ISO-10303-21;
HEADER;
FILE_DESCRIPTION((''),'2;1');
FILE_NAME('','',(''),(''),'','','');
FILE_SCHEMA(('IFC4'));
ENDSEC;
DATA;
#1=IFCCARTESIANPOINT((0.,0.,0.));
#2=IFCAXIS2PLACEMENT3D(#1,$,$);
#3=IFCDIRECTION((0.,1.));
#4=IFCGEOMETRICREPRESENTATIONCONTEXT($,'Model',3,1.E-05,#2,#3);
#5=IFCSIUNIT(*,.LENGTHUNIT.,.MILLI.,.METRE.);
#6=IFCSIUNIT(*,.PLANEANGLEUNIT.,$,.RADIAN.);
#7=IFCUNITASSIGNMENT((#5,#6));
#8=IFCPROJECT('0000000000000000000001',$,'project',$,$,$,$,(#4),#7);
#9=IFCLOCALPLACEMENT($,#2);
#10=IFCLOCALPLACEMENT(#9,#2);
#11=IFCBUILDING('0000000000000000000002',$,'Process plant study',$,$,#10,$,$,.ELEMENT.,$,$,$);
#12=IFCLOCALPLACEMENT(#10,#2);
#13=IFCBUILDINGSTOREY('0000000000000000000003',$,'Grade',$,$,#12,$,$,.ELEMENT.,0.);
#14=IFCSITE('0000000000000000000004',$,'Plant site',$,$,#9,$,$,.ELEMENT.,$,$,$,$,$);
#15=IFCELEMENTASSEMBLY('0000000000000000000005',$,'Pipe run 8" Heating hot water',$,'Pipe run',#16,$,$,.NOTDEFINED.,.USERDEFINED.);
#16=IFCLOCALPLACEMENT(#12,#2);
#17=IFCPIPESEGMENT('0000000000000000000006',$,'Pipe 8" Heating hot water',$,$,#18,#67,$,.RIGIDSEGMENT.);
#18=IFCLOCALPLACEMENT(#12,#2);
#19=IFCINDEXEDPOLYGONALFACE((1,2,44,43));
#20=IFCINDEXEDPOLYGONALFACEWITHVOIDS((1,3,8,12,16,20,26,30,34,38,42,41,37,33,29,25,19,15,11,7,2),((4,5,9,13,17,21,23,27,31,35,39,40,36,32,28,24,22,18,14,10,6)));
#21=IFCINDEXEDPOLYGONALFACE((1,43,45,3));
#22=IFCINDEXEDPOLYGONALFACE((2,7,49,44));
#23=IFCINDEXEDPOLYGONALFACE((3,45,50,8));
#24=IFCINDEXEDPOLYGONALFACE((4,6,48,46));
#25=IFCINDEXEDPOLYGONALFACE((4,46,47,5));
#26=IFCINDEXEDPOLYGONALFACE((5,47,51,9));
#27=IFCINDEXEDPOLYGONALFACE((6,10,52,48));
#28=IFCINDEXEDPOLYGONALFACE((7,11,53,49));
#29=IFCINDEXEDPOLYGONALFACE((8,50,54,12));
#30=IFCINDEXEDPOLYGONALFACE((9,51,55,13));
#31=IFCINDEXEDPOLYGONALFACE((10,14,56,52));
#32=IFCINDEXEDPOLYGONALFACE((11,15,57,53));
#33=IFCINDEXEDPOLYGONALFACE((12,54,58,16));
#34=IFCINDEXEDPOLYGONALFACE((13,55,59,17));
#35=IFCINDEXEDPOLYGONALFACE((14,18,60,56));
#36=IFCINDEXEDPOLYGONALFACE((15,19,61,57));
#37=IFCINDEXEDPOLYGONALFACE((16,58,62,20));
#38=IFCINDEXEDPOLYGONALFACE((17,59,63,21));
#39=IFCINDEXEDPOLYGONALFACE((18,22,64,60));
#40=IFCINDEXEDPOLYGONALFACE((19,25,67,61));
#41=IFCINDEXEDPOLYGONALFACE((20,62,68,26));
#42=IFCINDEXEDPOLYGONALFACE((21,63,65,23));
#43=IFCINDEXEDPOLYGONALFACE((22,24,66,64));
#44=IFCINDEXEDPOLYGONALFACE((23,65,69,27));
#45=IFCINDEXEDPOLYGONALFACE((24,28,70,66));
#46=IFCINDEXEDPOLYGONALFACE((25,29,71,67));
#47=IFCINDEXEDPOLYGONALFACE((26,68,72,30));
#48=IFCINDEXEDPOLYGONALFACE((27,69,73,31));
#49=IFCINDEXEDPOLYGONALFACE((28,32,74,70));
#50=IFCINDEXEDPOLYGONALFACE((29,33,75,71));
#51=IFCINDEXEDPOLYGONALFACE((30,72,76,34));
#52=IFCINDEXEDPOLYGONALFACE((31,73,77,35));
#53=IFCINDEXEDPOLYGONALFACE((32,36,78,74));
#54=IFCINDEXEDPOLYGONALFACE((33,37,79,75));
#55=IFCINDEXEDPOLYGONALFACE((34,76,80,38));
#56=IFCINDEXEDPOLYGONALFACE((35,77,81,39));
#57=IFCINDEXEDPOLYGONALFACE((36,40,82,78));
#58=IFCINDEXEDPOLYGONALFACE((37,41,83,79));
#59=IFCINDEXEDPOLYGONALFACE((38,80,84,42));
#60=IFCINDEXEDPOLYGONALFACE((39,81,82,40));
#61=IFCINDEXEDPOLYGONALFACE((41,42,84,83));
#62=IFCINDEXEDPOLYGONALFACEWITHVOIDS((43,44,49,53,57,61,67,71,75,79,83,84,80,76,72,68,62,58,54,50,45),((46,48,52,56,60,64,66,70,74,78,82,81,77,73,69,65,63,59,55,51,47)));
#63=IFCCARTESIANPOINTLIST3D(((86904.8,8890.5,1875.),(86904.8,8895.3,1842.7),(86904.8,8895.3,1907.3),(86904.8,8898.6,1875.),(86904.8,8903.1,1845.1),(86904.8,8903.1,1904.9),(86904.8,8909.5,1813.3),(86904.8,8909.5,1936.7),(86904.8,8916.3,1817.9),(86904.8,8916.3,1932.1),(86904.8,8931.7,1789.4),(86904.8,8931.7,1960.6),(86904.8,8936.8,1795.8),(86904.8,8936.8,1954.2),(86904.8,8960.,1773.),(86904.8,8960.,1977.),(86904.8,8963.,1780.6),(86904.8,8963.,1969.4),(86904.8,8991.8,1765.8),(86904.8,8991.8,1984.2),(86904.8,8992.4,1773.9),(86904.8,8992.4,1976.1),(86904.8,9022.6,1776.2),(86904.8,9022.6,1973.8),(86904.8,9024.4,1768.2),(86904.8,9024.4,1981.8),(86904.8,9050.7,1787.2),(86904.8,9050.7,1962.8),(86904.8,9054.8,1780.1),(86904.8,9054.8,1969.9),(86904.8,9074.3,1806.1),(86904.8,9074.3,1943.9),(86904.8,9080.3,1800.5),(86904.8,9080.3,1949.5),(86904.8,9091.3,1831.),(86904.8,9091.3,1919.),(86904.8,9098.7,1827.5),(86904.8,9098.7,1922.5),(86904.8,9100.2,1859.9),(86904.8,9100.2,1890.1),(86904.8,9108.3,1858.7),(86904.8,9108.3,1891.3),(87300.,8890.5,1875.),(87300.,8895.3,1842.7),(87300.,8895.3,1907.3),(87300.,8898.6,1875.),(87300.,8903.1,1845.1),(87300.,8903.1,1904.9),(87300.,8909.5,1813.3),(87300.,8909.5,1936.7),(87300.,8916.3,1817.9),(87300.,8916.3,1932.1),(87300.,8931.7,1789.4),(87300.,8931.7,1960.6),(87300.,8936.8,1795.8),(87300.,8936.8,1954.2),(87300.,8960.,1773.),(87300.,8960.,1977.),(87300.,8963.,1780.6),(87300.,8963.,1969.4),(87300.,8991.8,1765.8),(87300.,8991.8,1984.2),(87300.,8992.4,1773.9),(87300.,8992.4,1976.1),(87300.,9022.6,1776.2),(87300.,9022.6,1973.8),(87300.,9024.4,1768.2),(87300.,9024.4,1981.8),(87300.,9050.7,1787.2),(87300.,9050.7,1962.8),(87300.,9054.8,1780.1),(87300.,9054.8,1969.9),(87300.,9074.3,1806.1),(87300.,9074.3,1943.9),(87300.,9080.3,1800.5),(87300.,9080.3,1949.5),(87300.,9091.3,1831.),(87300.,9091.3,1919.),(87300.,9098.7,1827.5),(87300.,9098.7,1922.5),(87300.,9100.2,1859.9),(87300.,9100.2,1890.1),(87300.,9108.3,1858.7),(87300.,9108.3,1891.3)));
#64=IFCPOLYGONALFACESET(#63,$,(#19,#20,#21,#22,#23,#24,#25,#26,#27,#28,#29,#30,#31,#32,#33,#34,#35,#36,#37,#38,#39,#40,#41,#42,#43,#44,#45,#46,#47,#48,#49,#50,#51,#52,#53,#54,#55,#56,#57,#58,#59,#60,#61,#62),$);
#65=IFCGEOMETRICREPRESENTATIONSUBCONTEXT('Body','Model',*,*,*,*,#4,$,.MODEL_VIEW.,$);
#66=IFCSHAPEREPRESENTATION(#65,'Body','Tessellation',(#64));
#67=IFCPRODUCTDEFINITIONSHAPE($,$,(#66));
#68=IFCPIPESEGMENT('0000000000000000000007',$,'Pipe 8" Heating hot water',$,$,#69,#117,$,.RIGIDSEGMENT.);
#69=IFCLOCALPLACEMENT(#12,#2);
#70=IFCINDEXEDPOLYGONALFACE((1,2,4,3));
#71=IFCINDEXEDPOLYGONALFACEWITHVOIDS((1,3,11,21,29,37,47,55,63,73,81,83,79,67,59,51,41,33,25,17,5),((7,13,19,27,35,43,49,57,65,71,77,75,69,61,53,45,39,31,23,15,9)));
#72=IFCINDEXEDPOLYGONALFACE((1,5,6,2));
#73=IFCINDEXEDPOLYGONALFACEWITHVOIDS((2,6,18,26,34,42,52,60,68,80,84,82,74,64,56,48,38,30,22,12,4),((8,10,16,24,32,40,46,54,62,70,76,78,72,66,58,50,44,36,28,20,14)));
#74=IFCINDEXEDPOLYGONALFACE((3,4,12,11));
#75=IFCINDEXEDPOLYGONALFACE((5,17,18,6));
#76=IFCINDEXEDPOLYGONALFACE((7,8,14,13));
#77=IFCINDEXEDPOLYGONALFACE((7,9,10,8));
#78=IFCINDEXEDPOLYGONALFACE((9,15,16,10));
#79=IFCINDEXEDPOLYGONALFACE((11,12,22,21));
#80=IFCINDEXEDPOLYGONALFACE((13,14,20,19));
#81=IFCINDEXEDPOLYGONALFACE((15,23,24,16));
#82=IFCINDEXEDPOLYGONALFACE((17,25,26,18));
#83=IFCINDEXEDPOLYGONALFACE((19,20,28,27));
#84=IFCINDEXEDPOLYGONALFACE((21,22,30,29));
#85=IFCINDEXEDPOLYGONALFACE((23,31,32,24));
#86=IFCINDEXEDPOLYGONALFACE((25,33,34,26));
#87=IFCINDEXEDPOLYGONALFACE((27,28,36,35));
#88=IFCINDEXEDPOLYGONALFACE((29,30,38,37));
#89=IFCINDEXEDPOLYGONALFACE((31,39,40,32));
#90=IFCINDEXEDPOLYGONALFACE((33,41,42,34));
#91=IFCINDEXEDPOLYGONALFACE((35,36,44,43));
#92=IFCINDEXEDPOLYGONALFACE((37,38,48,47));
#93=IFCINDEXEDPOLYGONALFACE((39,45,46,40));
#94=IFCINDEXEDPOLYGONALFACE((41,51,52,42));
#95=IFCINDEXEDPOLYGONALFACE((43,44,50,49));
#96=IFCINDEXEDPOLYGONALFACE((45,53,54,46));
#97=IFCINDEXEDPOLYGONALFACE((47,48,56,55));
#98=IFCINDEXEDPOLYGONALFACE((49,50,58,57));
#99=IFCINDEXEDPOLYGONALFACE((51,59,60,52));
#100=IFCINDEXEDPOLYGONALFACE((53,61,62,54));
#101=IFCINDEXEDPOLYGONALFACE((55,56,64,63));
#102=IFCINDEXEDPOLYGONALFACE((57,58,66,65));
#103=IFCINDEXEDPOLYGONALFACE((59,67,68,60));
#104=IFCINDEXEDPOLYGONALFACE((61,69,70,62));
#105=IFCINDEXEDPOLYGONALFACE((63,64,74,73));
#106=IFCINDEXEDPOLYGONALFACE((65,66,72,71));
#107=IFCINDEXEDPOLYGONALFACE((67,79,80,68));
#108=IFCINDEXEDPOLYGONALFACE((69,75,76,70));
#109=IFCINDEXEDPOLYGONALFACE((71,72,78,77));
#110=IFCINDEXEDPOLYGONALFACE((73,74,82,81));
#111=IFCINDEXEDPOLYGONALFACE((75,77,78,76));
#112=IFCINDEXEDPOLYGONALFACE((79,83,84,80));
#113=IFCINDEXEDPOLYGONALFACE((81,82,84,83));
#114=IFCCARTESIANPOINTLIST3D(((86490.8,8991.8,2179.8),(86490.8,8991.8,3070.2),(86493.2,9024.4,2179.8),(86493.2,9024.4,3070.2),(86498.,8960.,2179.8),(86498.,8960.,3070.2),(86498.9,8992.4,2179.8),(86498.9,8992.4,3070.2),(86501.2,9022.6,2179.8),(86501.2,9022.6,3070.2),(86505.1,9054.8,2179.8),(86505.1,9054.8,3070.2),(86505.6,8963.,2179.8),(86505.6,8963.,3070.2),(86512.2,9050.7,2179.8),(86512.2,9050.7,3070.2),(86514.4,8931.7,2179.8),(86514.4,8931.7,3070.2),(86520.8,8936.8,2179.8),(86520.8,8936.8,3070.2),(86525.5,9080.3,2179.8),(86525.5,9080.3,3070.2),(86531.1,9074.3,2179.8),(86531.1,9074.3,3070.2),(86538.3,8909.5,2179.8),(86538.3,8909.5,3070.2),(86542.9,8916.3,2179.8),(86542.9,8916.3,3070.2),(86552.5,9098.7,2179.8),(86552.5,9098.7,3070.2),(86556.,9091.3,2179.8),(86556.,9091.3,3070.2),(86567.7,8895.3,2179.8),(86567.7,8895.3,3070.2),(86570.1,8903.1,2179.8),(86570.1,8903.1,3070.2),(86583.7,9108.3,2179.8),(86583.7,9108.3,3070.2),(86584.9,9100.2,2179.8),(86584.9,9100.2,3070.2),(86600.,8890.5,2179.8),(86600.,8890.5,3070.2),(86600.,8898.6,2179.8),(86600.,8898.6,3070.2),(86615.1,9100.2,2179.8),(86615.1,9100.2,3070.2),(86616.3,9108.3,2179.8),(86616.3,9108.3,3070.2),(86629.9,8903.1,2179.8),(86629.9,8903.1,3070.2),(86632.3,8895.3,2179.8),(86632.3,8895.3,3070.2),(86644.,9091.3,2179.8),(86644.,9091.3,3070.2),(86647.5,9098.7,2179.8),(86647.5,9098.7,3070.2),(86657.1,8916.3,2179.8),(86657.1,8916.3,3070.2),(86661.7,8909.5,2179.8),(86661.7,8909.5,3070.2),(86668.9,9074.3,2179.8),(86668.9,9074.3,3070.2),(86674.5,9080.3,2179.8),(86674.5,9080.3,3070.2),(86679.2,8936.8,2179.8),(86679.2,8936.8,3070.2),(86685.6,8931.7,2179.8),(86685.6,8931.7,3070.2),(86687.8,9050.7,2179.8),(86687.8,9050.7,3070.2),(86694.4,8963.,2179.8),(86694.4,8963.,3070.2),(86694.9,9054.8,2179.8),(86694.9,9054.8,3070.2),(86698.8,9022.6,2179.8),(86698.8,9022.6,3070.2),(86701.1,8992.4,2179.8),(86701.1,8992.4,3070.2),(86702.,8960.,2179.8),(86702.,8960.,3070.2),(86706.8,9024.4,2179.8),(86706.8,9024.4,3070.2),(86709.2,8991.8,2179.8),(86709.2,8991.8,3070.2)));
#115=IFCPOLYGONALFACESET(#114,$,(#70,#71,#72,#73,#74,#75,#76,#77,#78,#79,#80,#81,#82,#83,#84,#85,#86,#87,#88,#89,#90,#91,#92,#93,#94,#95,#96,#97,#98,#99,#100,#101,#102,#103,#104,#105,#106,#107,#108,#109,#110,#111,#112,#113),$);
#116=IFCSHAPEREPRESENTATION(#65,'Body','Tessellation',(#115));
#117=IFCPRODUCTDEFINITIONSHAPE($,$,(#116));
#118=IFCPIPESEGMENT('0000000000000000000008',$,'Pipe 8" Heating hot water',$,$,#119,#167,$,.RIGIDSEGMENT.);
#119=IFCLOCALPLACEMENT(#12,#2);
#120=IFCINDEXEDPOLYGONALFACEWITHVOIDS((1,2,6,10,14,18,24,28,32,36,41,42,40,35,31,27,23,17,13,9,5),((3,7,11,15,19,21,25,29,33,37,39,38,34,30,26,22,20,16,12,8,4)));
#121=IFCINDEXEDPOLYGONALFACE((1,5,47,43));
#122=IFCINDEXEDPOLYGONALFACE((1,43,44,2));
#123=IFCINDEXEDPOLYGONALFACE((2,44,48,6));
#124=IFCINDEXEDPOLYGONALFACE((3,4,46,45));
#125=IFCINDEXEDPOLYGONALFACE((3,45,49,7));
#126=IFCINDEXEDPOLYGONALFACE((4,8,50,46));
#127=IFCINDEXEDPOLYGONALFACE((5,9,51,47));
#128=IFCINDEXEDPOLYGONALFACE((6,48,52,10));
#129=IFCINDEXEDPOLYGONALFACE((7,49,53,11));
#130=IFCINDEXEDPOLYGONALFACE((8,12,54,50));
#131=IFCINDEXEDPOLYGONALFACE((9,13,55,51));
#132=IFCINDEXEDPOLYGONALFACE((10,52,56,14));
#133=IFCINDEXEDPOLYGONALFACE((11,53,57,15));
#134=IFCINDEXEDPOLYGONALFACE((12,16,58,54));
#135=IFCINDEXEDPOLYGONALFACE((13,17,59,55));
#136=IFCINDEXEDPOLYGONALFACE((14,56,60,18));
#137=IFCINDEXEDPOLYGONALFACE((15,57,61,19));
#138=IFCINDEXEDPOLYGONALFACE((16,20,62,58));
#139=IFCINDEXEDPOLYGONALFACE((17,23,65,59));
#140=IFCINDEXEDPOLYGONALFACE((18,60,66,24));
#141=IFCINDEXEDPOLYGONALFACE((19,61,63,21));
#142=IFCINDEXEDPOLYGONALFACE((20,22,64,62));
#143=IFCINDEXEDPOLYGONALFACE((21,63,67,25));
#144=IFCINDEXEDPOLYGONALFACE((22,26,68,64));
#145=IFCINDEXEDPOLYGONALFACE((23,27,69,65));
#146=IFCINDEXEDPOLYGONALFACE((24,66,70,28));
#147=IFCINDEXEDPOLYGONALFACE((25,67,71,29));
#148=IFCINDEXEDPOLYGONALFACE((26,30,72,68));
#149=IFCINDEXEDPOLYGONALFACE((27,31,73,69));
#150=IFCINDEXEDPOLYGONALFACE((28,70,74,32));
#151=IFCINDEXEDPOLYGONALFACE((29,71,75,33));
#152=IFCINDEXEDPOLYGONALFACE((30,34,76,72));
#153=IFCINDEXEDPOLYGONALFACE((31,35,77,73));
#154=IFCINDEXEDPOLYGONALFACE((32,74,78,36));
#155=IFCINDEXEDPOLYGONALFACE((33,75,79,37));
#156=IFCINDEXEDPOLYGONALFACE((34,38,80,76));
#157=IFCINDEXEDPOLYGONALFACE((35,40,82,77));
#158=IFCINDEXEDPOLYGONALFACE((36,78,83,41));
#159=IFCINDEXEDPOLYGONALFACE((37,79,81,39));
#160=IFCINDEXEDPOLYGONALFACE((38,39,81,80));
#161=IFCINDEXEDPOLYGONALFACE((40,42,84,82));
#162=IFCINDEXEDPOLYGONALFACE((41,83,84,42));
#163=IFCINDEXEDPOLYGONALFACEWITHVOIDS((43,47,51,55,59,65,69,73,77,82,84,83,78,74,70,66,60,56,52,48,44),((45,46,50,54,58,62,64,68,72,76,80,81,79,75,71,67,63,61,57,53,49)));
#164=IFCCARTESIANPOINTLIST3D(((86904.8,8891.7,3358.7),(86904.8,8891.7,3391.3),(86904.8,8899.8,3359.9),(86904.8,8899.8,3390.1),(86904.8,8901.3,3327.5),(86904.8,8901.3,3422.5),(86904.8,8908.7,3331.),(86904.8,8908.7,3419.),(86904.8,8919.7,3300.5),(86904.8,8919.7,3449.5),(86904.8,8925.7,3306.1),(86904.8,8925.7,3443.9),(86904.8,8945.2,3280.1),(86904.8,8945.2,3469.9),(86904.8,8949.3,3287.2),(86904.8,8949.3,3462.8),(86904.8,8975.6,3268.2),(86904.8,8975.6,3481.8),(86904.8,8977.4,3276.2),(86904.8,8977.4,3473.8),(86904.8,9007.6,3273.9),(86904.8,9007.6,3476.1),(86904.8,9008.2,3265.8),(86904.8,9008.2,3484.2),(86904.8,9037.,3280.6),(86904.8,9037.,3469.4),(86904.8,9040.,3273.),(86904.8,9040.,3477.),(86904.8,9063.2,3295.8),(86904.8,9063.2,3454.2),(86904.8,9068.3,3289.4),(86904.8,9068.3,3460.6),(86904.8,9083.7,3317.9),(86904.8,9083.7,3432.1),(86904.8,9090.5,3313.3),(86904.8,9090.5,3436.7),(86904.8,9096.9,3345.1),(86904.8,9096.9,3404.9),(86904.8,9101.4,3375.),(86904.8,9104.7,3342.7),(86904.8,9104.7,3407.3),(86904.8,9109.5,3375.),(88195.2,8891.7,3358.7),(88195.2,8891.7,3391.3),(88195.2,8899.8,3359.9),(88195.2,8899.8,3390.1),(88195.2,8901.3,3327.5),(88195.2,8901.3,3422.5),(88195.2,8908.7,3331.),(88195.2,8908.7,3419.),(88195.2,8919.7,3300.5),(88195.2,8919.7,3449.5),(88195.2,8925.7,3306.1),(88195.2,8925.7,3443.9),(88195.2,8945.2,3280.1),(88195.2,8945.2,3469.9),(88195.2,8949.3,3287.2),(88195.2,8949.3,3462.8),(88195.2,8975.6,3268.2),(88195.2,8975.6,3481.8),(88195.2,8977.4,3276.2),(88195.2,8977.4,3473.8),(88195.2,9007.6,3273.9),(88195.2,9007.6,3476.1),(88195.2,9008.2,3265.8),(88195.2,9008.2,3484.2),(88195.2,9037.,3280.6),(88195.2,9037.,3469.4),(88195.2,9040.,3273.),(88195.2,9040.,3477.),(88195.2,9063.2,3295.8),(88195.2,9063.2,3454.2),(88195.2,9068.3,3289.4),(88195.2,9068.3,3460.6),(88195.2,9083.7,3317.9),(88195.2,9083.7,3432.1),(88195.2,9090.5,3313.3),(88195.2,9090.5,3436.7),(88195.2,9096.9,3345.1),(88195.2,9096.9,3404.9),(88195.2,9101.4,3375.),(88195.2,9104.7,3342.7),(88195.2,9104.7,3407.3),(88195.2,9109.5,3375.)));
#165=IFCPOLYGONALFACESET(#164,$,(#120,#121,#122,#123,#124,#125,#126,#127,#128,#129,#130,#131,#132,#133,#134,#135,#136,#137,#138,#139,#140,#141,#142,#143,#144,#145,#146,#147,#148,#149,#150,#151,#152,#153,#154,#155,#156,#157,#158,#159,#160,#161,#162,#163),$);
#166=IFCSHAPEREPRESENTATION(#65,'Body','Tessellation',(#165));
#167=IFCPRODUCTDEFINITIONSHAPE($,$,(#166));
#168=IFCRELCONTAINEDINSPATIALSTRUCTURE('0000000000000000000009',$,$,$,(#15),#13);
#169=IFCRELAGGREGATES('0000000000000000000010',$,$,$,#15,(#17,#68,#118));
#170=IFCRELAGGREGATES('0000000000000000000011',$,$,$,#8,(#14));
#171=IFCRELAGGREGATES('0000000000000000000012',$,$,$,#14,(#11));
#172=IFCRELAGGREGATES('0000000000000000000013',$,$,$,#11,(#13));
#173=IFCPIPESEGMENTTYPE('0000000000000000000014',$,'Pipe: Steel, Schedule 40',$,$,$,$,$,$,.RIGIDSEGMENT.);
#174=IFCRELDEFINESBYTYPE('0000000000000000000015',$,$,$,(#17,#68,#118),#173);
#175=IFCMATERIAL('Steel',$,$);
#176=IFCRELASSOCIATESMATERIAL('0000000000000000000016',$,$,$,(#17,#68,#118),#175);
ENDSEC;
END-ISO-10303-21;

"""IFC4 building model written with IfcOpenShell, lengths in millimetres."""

from ifc_helpers import new_model, si_unit, direction, frame, origin, origin_with_axes, origin_2d, place, context, subcontext, project, spatial, hollow_circle, extrude, material, type_object, element, aggregate, save


model = new_model("IFC4")

# Units and contexts
model_context = context("Model", 3, precision=1e-05, world=origin(), true_north=direction((0.0, 1.0)))
body_context = subcontext(model_context, "Body", "Model", "MODEL_VIEW")
ifc_project = project(units=[si_unit("LENGTHUNIT", "METRE", prefix="MILLI"), si_unit("PLANEANGLEUNIT", "RADIAN")], contexts=[model_context])

# Site, building, storey
site_placement = place(None, origin())
site = spatial("IfcSite", under=ifc_project, at=site_placement, Name="Plant site", CompositionType="ELEMENT")
building_placement = place(site_placement, origin())
building = spatial("IfcBuilding", under=site, at=building_placement, Name="Process plant study", CompositionType="ELEMENT")
storey_placement = place(building_placement, origin())
storey = spatial("IfcBuildingStorey", under=building, at=storey_placement, Name="Grade", CompositionType="ELEMENT", Elevation=0.0)

# Shared definitions
ifc_material = material(Name="Steel")
pipe_segment_type = type_object("IfcPipeSegmentType", Name="Pipe: Steel, Schedule 40", PredefinedType="RIGIDSEGMENT")

# Element assembly, pipe segments
assembly_1_placement = place(storey_placement, origin_with_axes())
assembly_1 = element("IfcElementAssembly", 1, at=assembly_1_placement, inside=storey, Name="Pipe run 8\" Heating hot water", ObjectType="Pipe run", AssemblyPlace="NOTDEFINED", PredefinedType="USERDEFINED")
pipe_segment_1_placement = place(storey_placement, origin_with_axes())
pipe_segment_1 = element("IfcPipeSegment", 2, at=pipe_segment_1_placement, type_object=pipe_segment_type, material=ifc_material, Name="Pipe 8\" Heating hot water", PredefinedType="RIGIDSEGMENT", context=body_context, shape_type="SweptSolid", body=[
    extrude(hollow_circle(Radius=109.5, WallThickness=8.2, at=origin_2d()), frame((87300.0, 9000.0, 1875.0), z_axis=(-1.0, 0.0, 0.0), x_axis=(0.0, -1.0, 0.0)), (0.0, 0.0, 1.0), 395.2),
])
pipe_segment_2_placement = place(storey_placement, origin_with_axes())
pipe_segment_2 = element("IfcPipeSegment", 3, at=pipe_segment_2_placement, type_object=pipe_segment_type, material=ifc_material, Name="Pipe 8\" Heating hot water", PredefinedType="RIGIDSEGMENT", context=body_context, shape_type="SweptSolid", body=[
    extrude(hollow_circle(Radius=109.5, WallThickness=8.2, at=origin_2d()), frame((86600.0, 9000.0, 2179.8), z_axis=(0.0, 0.0, 1.0), x_axis=(0.0, -1.0, 0.0)), (0.0, 0.0, 1.0), 890.4),
])
pipe_segment_3_placement = place(storey_placement, origin_with_axes())
pipe_segment_3 = element("IfcPipeSegment", 4, at=pipe_segment_3_placement, type_object=pipe_segment_type, material=ifc_material, Name="Pipe 8\" Heating hot water", PredefinedType="RIGIDSEGMENT", context=body_context, shape_type="SweptSolid", body=[
    extrude(hollow_circle(Radius=109.5, WallThickness=8.2, at=origin_2d()), frame((86904.8, 9000.0, 3375.0), z_axis=(1.0, 0.0, 0.0), x_axis=(0.0, 1.0, 0.0)), (0.0, 0.0, 1.0), 1290.4),
])

aggregate(assembly_1, [pipe_segment_1, pipe_segment_2, pipe_segment_3])

save(model, "model.ifc")
